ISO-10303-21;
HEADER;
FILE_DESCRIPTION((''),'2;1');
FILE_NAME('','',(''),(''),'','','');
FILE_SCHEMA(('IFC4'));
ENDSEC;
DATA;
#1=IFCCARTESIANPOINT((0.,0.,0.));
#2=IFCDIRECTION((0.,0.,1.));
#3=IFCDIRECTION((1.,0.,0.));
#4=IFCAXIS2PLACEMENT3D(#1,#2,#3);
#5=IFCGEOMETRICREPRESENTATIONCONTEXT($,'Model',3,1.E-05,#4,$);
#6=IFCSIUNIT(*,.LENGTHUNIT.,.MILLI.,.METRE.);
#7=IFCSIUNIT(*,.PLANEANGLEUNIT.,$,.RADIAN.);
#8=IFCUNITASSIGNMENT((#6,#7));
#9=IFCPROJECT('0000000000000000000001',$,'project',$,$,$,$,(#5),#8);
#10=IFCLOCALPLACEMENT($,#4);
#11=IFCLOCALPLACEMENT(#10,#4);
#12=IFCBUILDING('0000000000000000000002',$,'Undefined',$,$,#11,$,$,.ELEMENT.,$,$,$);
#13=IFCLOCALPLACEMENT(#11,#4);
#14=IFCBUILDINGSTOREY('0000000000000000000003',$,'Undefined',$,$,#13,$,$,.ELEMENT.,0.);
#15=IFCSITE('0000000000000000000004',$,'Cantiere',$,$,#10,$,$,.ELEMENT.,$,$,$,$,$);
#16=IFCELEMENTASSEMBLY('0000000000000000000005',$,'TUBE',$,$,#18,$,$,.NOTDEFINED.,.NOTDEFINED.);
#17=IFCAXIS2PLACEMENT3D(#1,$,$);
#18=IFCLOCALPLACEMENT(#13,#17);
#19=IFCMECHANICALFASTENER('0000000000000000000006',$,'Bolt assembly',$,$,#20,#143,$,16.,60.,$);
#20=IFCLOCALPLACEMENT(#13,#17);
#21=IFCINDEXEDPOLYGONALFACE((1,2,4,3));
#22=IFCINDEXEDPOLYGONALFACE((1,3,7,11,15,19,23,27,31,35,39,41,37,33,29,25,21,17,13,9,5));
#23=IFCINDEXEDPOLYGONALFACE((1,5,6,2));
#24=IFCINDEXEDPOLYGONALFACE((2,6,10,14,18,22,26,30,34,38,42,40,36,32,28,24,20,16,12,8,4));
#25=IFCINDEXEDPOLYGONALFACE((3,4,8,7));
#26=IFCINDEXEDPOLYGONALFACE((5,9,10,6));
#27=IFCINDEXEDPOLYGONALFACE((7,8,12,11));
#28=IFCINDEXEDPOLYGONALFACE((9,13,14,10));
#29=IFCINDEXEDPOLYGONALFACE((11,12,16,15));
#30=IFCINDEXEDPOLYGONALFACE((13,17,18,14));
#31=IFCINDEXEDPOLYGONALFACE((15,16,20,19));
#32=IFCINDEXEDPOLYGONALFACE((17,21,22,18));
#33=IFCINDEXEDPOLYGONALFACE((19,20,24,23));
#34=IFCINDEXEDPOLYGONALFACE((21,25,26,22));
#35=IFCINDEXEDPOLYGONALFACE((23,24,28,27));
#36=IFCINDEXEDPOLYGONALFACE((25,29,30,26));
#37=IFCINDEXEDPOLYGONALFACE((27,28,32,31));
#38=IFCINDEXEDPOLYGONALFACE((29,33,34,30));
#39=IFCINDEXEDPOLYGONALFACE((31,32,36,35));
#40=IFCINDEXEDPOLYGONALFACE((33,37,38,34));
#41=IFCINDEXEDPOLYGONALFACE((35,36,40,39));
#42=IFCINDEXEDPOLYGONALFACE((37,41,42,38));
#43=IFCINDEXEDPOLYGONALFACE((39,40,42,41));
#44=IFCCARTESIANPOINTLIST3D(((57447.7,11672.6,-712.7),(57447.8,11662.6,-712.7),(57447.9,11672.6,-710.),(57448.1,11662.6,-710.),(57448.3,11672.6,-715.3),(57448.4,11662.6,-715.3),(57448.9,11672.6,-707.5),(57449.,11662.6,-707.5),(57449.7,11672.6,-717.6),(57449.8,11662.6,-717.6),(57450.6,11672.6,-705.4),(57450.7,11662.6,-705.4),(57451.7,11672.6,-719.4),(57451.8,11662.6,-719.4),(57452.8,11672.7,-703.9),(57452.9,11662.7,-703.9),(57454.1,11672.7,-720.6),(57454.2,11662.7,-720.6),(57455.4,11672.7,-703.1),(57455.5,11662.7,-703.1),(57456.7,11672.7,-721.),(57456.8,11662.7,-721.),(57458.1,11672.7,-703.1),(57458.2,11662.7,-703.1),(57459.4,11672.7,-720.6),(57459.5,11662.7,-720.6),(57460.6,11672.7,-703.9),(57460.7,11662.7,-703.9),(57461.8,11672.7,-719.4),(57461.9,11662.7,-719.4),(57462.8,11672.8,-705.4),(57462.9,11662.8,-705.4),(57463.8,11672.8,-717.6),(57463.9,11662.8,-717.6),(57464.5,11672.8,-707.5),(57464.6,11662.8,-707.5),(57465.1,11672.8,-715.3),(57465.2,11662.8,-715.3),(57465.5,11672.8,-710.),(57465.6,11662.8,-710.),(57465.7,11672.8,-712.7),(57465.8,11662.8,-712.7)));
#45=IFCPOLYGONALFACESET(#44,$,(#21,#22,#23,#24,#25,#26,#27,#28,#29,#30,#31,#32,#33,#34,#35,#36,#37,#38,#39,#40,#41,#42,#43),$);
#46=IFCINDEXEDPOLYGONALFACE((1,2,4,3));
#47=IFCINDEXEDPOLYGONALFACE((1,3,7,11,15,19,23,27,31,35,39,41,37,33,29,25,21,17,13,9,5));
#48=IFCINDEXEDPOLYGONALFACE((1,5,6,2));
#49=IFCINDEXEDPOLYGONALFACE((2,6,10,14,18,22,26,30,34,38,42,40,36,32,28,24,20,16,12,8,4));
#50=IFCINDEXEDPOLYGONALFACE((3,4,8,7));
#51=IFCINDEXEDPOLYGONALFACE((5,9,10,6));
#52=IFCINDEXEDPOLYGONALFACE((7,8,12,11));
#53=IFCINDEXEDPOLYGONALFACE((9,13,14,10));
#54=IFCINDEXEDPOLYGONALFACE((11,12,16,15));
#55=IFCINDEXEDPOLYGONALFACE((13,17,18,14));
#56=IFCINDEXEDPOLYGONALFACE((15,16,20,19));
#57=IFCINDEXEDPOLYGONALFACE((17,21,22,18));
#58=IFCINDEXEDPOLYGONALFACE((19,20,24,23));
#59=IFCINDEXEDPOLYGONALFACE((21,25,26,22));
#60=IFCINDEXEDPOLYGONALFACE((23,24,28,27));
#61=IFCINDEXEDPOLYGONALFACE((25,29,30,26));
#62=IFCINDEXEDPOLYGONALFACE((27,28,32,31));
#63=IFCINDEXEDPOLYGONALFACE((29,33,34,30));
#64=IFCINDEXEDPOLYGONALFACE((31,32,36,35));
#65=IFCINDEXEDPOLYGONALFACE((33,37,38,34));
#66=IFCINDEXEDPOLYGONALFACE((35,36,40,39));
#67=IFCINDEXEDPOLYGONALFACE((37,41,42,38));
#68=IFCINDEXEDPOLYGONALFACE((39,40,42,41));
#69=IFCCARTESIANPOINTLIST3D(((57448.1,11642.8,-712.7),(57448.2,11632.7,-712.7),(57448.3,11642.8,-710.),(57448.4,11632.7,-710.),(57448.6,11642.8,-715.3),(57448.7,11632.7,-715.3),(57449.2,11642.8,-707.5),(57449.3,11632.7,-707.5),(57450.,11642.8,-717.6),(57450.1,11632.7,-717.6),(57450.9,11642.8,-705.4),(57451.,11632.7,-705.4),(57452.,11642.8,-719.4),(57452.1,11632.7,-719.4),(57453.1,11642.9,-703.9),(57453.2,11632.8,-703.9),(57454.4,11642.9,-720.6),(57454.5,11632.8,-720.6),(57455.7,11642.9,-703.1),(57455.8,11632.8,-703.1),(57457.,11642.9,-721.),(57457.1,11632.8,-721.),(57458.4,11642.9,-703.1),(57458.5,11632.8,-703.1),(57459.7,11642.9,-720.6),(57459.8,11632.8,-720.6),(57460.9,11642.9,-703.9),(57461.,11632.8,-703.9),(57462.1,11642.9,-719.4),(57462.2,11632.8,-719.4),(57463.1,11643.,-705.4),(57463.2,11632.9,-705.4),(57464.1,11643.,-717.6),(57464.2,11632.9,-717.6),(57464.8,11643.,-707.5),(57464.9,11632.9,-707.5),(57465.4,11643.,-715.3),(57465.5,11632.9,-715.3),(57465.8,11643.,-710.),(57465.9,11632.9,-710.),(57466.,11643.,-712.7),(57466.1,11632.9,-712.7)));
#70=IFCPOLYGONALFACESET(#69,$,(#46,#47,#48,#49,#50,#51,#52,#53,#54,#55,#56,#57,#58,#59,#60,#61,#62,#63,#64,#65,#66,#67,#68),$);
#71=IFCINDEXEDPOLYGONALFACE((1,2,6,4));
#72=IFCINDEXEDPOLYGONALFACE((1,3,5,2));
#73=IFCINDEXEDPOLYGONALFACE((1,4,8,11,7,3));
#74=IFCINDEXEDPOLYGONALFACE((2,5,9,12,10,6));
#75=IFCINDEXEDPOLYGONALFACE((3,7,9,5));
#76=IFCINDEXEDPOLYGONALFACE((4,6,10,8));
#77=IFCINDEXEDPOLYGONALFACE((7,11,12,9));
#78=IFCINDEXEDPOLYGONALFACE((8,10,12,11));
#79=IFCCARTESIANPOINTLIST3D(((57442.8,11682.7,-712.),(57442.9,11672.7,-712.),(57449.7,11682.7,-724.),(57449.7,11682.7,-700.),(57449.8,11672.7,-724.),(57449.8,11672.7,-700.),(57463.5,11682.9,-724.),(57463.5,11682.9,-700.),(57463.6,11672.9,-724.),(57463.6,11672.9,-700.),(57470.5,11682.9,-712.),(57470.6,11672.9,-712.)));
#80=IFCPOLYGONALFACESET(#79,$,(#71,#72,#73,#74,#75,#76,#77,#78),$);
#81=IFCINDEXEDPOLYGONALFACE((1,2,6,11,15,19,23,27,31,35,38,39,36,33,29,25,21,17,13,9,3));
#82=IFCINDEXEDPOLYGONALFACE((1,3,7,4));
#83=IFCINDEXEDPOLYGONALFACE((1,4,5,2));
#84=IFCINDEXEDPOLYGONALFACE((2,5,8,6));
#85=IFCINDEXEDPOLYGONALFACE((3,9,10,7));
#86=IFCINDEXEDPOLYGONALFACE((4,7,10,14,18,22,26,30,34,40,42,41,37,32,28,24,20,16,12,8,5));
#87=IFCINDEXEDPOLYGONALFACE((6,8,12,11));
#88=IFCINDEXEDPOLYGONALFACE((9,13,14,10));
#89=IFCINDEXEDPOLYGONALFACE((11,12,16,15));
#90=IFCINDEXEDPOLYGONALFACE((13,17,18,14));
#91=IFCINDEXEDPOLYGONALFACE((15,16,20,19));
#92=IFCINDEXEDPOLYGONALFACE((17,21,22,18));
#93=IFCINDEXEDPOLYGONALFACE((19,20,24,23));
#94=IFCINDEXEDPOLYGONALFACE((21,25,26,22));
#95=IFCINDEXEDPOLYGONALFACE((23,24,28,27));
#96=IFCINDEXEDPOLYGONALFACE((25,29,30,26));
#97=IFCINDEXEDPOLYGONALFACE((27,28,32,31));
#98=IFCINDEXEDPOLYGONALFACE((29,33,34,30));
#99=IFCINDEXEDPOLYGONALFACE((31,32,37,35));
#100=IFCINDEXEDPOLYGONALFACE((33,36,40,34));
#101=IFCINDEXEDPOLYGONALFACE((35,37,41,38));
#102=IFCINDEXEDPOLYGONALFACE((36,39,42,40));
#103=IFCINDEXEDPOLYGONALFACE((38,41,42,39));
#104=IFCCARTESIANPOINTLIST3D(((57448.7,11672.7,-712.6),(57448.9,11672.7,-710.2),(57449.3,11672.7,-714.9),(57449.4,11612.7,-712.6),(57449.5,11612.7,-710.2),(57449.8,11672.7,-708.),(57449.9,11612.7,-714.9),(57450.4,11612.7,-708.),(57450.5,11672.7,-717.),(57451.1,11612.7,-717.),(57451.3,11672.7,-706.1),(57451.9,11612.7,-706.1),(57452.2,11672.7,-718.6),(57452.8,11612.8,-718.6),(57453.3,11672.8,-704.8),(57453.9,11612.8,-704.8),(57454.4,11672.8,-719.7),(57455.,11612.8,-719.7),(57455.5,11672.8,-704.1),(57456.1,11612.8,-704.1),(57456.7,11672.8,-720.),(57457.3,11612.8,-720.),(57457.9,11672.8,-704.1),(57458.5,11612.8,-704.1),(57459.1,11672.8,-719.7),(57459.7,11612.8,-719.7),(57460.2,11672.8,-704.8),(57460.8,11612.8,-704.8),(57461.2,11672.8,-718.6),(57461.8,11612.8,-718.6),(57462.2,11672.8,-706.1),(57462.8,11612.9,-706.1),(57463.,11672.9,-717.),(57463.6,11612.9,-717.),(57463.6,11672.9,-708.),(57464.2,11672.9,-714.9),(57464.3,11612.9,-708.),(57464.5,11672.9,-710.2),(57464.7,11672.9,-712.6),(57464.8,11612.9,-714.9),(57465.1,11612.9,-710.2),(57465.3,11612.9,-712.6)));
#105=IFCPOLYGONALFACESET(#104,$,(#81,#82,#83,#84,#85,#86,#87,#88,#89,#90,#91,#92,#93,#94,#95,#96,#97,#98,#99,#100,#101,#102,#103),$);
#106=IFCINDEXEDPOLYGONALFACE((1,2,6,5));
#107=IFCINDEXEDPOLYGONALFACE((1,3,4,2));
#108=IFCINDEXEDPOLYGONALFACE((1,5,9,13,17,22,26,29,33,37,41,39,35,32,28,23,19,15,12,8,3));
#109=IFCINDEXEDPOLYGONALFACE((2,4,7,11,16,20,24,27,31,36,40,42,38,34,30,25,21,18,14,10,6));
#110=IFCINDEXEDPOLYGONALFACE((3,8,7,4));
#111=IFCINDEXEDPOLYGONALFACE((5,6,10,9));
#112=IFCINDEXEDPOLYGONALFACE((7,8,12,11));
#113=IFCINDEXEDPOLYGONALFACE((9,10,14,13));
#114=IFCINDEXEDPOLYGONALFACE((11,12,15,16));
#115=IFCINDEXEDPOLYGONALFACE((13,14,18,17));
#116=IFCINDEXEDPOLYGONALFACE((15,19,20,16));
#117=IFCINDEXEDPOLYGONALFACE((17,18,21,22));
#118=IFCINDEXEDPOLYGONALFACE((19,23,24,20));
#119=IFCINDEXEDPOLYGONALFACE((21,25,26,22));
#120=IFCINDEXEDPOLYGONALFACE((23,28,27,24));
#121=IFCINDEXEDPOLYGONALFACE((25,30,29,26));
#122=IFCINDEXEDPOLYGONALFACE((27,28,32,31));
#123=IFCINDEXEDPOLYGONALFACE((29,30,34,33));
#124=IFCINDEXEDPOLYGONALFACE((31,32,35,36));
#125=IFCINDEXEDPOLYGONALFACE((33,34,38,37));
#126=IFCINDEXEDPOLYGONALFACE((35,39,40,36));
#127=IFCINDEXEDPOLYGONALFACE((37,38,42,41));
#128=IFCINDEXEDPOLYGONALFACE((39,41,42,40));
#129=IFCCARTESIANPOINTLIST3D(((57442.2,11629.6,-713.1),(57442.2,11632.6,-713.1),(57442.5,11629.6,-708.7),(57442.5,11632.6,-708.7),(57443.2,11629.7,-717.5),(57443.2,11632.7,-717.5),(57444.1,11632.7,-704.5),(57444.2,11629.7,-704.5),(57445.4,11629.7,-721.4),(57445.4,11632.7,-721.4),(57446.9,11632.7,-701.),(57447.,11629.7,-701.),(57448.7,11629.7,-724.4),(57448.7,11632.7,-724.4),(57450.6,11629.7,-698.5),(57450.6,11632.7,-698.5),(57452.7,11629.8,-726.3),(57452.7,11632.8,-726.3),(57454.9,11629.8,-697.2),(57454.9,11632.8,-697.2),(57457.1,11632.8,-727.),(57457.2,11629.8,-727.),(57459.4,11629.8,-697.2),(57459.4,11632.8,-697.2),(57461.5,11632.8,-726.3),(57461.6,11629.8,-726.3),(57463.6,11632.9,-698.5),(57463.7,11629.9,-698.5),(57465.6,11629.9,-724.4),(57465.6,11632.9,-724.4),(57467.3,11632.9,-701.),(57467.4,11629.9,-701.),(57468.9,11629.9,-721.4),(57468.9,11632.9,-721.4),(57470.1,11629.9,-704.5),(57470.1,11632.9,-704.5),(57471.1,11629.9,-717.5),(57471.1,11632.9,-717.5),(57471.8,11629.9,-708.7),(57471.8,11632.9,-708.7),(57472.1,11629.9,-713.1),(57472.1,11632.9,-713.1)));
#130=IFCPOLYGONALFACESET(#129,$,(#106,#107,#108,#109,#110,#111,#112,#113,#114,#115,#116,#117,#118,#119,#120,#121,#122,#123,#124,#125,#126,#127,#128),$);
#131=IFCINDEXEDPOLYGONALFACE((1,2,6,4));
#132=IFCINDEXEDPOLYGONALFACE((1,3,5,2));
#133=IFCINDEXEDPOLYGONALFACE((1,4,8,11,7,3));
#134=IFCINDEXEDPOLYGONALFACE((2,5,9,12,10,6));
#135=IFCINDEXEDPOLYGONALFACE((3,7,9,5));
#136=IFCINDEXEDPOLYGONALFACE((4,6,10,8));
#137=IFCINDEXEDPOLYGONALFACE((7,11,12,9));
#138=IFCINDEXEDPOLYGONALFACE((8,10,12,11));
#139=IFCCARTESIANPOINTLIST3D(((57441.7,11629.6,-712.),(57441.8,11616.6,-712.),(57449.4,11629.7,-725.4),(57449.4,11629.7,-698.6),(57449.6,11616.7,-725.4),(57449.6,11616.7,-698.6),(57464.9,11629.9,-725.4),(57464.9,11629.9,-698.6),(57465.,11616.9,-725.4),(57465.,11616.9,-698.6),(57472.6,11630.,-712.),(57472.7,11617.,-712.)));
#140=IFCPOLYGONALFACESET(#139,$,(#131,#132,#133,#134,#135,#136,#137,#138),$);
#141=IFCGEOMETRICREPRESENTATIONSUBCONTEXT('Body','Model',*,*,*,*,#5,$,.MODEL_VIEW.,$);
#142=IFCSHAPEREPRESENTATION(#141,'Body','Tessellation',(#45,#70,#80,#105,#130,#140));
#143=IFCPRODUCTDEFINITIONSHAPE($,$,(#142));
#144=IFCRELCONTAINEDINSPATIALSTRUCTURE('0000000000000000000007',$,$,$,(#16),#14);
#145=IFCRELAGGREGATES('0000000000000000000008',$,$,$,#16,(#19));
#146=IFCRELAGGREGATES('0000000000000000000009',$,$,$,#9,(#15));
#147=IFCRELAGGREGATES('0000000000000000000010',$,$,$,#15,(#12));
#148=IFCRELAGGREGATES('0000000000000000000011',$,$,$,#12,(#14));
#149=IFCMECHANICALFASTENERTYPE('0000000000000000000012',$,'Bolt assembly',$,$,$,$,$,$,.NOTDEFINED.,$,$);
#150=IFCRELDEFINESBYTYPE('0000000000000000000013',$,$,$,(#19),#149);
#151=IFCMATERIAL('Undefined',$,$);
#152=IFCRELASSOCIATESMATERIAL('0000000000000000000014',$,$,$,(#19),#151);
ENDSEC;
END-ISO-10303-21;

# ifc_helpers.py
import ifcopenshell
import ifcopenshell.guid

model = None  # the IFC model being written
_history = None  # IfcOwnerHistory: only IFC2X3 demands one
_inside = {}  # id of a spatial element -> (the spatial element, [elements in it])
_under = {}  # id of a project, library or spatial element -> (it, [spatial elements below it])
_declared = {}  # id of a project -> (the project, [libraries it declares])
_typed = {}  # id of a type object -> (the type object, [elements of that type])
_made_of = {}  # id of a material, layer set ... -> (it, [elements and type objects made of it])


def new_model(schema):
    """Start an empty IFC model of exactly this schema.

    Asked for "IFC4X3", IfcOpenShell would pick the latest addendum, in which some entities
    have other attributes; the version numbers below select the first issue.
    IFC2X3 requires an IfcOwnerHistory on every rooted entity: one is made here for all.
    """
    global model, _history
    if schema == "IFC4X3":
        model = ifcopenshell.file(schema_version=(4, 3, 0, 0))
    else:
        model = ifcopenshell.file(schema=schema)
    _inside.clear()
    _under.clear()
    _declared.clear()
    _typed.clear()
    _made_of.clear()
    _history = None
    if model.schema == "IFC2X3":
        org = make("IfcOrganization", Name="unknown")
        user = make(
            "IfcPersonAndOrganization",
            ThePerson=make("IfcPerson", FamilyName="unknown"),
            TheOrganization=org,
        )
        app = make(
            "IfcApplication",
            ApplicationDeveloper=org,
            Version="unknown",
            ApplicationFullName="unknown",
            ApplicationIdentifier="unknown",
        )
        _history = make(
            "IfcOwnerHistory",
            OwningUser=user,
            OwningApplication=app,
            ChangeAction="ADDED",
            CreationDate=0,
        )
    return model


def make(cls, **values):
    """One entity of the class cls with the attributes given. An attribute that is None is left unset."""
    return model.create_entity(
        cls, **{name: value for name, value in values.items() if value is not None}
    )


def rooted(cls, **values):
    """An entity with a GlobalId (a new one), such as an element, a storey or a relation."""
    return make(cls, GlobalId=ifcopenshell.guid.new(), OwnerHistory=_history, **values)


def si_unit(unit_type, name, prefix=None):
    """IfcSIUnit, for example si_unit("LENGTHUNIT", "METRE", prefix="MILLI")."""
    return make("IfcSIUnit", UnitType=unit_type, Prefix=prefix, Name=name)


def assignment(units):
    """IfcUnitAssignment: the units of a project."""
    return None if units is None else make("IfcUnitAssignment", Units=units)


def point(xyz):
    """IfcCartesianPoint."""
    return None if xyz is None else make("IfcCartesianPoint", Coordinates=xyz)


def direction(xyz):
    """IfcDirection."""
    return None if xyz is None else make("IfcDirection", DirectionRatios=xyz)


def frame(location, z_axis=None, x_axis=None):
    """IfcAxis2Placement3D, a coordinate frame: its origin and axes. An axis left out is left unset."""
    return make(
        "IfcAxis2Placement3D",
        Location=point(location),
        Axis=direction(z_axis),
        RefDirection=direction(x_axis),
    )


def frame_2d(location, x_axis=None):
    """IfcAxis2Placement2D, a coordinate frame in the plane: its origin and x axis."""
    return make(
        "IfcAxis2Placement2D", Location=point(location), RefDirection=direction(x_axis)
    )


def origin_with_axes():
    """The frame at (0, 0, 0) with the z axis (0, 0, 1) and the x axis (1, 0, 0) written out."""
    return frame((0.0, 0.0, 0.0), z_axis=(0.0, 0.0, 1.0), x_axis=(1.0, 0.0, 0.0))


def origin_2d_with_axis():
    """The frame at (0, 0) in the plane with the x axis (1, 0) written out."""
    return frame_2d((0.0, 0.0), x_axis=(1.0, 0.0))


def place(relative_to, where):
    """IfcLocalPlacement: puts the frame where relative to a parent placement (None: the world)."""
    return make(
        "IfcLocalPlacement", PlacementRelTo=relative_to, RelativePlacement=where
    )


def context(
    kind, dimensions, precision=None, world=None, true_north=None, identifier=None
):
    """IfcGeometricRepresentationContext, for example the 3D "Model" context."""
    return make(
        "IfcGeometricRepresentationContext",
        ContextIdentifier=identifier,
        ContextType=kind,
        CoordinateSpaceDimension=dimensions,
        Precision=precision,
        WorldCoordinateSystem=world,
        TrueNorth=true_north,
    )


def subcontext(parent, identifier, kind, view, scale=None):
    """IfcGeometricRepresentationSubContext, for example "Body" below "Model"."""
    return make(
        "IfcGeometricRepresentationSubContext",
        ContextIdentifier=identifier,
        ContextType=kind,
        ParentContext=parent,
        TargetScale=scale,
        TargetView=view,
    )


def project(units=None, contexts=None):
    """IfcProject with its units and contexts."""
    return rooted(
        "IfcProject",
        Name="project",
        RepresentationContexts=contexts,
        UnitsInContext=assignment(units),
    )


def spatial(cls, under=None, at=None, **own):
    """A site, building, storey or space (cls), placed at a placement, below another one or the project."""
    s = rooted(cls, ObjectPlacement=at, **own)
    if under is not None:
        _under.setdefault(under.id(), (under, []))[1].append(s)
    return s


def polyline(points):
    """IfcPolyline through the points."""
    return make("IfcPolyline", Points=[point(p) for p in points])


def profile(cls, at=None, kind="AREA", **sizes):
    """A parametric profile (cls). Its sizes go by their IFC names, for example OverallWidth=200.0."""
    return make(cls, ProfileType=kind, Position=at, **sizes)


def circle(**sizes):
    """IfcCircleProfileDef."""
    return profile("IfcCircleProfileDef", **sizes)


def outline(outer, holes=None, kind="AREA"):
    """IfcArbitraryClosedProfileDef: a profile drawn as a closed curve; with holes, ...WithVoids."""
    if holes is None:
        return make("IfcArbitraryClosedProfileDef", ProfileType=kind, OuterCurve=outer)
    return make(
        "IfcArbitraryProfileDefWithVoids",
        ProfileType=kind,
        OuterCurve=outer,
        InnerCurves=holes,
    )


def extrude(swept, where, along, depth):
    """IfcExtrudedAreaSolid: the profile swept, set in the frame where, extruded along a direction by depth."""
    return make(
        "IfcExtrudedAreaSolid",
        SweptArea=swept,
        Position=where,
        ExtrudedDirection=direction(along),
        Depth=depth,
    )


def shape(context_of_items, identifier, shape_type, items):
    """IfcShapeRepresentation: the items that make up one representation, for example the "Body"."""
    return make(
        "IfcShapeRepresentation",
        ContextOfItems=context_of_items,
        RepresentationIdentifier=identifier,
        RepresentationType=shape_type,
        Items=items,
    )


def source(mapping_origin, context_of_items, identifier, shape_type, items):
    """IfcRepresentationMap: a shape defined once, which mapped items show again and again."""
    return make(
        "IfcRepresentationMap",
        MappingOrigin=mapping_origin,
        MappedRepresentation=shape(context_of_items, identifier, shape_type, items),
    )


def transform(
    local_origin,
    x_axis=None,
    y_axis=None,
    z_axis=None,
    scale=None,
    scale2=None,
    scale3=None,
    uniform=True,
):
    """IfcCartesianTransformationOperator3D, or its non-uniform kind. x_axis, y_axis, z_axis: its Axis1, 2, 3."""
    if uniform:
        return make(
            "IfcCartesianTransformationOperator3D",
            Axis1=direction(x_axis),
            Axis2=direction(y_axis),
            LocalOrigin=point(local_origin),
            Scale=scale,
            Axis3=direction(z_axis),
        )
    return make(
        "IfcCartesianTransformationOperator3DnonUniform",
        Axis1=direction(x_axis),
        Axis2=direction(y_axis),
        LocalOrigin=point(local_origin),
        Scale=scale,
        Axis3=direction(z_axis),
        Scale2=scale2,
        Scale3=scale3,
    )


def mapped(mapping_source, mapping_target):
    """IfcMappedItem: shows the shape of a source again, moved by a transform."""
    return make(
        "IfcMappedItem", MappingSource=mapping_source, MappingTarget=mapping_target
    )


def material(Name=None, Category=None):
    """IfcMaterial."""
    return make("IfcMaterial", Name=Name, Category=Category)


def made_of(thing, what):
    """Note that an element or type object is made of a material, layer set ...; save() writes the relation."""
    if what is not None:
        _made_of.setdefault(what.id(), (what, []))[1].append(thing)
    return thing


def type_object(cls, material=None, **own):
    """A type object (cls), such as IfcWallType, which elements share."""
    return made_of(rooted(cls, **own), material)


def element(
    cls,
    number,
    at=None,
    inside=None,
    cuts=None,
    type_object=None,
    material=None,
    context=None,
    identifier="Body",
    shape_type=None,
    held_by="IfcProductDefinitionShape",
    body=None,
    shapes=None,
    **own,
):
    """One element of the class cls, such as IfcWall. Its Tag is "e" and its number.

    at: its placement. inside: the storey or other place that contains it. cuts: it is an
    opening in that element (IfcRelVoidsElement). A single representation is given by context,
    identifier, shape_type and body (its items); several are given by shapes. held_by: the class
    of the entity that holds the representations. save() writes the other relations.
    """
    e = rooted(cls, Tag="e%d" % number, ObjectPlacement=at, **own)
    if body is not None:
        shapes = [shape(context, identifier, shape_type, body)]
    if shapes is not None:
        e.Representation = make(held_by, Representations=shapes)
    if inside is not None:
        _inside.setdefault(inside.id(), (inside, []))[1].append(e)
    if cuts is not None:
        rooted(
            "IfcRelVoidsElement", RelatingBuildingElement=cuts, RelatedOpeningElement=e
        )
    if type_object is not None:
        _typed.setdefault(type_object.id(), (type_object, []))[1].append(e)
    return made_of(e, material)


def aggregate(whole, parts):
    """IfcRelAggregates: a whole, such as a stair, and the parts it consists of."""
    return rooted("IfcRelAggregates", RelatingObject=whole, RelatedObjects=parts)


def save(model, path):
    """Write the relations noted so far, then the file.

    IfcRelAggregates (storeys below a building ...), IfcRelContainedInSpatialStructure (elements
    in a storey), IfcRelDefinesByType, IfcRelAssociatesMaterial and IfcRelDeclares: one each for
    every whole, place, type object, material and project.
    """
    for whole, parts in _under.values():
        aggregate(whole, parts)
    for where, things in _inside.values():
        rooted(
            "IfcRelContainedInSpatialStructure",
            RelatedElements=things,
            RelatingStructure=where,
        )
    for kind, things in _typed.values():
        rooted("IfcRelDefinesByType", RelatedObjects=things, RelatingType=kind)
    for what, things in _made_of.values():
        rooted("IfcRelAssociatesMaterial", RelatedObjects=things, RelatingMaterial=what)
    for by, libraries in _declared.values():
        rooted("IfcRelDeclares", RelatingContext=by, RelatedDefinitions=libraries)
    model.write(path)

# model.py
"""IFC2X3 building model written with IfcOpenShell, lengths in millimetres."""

from ifc_helpers import new_model, si_unit, frame, origin_with_axes, origin_2d_with_axis, place, context, subcontext, project, spatial, polyline, circle, outline, extrude, source, transform, mapped, material, type_object, element, aggregate, save


model = new_model("IFC2X3")

# Units and contexts
model_context = context("Model", 3, precision=1e-05, world=origin_with_axes())
body_context = subcontext(model_context, "Body", "Model", "MODEL_VIEW")
ifc_project = project(units=[si_unit("LENGTHUNIT", "METRE", prefix="MILLI"), si_unit("PLANEANGLEUNIT", "RADIAN")], contexts=[model_context])

# Site, building, storey
site_placement = place(None, origin_with_axes())
site = spatial("IfcSite", under=ifc_project, at=site_placement, Name="Cantiere", CompositionType="ELEMENT")
building_placement = place(site_placement, origin_with_axes())
building = spatial("IfcBuilding", under=site, at=building_placement, Name="Undefined", CompositionType="ELEMENT")
storey_placement = place(building_placement, origin_with_axes())
storey = spatial("IfcBuildingStorey", under=building, at=storey_placement, Name="Undefined", CompositionType="ELEMENT", Elevation=0.0)

# Element assembly
assembly_1_placement = place(storey_placement, origin_with_axes())
assembly_1 = element("IfcElementAssembly", 1, at=assembly_1_placement, inside=storey, Name="TUBE", AssemblyPlace="NOTDEFINED", PredefinedType="NOTDEFINED")

# Mechanical fastener
ifc_material_1 = material(Name="Undefined")
mechanical_fastener_type = type_object("IfcMechanicalFastenerType", Name="Bolt assembly")
shared_shape_1 = source(origin_with_axes(), body_context, "Body", "SweptSolid", [
    extrude(circle(Radius=9.0, at=origin_2d_with_axis()), frame((0.0, -19.9, 0.0), z_axis=(0.0, 1.0, 0.0), x_axis=(1.0, 0.0, 0.0)), (0.0, 0.0, 1.0), 10.0),
    extrude(circle(Radius=9.0, at=origin_2d_with_axis()), frame((0.0, 9.9, 0.0), z_axis=(0.0, 1.0, 0.0), x_axis=(1.0, 0.0, 0.0)), (0.0, 0.0, 1.0), 10.1),
    extrude(outline(polyline([(12.0, -6.9), (12.0, 6.9), (0.0, 13.9), (-12.0, 6.9), (-12.0, -6.9), (0.0, -13.9), (12.0, -6.9)])), frame((0.0, -30.0, 0.0), z_axis=(0.0, 1.0, 0.0), x_axis=(1.0, 0.0, 0.0)), (0.0, 0.0, 1.0), 10.0),
    extrude(circle(Radius=8.0, at=origin_2d_with_axis()), frame((0.0, -20.0, 0.0), z_axis=(0.0, 1.0, 0.0), x_axis=(1.0, 0.0, 0.0)), (0.0, 0.0, 1.0), 60.0),
    extrude(circle(Radius=15.0, at=origin_2d_with_axis()), frame((0.0, 20.0, 0.0), z_axis=(0.0, 1.0, 0.0), x_axis=(1.0, 0.0, 0.0)), (0.0, 0.0, 1.0), 3.0),
    extrude(outline(polyline([(13.4, -7.7), (13.4, 7.7), (0.0, 15.4), (-13.4, 7.7), (-13.4, -7.7), (0.0, -15.4), (13.4, -7.7)])), frame((0.0, 23.0, 0.0), z_axis=(0.0, 1.0, 0.0), x_axis=(1.0, 0.0, 0.0)), (0.0, 0.0, 1.0), 13.0),
])
mechanical_fastener_1_placement = place(assembly_1_placement, frame((57456.9, 11652.8, -712.0), z_axis=(-0.999949, -0.010139, 0.0), x_axis=(0.0, 0.000001, -1.0)))
mechanical_fastener_1 = element("IfcMechanicalFastener", 2, at=mechanical_fastener_1_placement, type_object=mechanical_fastener_type, material=ifc_material_1, Name="Bolt assembly", NominalDiameter=16.0, NominalLength=60.0, context=body_context, shape_type="MappedRepresentation", body=[
    mapped(shared_shape_1, transform((0.0, 0.0, 0.0))),
])
aggregate(assembly_1, [mechanical_fastener_1])

save(model, "model.ifc")
